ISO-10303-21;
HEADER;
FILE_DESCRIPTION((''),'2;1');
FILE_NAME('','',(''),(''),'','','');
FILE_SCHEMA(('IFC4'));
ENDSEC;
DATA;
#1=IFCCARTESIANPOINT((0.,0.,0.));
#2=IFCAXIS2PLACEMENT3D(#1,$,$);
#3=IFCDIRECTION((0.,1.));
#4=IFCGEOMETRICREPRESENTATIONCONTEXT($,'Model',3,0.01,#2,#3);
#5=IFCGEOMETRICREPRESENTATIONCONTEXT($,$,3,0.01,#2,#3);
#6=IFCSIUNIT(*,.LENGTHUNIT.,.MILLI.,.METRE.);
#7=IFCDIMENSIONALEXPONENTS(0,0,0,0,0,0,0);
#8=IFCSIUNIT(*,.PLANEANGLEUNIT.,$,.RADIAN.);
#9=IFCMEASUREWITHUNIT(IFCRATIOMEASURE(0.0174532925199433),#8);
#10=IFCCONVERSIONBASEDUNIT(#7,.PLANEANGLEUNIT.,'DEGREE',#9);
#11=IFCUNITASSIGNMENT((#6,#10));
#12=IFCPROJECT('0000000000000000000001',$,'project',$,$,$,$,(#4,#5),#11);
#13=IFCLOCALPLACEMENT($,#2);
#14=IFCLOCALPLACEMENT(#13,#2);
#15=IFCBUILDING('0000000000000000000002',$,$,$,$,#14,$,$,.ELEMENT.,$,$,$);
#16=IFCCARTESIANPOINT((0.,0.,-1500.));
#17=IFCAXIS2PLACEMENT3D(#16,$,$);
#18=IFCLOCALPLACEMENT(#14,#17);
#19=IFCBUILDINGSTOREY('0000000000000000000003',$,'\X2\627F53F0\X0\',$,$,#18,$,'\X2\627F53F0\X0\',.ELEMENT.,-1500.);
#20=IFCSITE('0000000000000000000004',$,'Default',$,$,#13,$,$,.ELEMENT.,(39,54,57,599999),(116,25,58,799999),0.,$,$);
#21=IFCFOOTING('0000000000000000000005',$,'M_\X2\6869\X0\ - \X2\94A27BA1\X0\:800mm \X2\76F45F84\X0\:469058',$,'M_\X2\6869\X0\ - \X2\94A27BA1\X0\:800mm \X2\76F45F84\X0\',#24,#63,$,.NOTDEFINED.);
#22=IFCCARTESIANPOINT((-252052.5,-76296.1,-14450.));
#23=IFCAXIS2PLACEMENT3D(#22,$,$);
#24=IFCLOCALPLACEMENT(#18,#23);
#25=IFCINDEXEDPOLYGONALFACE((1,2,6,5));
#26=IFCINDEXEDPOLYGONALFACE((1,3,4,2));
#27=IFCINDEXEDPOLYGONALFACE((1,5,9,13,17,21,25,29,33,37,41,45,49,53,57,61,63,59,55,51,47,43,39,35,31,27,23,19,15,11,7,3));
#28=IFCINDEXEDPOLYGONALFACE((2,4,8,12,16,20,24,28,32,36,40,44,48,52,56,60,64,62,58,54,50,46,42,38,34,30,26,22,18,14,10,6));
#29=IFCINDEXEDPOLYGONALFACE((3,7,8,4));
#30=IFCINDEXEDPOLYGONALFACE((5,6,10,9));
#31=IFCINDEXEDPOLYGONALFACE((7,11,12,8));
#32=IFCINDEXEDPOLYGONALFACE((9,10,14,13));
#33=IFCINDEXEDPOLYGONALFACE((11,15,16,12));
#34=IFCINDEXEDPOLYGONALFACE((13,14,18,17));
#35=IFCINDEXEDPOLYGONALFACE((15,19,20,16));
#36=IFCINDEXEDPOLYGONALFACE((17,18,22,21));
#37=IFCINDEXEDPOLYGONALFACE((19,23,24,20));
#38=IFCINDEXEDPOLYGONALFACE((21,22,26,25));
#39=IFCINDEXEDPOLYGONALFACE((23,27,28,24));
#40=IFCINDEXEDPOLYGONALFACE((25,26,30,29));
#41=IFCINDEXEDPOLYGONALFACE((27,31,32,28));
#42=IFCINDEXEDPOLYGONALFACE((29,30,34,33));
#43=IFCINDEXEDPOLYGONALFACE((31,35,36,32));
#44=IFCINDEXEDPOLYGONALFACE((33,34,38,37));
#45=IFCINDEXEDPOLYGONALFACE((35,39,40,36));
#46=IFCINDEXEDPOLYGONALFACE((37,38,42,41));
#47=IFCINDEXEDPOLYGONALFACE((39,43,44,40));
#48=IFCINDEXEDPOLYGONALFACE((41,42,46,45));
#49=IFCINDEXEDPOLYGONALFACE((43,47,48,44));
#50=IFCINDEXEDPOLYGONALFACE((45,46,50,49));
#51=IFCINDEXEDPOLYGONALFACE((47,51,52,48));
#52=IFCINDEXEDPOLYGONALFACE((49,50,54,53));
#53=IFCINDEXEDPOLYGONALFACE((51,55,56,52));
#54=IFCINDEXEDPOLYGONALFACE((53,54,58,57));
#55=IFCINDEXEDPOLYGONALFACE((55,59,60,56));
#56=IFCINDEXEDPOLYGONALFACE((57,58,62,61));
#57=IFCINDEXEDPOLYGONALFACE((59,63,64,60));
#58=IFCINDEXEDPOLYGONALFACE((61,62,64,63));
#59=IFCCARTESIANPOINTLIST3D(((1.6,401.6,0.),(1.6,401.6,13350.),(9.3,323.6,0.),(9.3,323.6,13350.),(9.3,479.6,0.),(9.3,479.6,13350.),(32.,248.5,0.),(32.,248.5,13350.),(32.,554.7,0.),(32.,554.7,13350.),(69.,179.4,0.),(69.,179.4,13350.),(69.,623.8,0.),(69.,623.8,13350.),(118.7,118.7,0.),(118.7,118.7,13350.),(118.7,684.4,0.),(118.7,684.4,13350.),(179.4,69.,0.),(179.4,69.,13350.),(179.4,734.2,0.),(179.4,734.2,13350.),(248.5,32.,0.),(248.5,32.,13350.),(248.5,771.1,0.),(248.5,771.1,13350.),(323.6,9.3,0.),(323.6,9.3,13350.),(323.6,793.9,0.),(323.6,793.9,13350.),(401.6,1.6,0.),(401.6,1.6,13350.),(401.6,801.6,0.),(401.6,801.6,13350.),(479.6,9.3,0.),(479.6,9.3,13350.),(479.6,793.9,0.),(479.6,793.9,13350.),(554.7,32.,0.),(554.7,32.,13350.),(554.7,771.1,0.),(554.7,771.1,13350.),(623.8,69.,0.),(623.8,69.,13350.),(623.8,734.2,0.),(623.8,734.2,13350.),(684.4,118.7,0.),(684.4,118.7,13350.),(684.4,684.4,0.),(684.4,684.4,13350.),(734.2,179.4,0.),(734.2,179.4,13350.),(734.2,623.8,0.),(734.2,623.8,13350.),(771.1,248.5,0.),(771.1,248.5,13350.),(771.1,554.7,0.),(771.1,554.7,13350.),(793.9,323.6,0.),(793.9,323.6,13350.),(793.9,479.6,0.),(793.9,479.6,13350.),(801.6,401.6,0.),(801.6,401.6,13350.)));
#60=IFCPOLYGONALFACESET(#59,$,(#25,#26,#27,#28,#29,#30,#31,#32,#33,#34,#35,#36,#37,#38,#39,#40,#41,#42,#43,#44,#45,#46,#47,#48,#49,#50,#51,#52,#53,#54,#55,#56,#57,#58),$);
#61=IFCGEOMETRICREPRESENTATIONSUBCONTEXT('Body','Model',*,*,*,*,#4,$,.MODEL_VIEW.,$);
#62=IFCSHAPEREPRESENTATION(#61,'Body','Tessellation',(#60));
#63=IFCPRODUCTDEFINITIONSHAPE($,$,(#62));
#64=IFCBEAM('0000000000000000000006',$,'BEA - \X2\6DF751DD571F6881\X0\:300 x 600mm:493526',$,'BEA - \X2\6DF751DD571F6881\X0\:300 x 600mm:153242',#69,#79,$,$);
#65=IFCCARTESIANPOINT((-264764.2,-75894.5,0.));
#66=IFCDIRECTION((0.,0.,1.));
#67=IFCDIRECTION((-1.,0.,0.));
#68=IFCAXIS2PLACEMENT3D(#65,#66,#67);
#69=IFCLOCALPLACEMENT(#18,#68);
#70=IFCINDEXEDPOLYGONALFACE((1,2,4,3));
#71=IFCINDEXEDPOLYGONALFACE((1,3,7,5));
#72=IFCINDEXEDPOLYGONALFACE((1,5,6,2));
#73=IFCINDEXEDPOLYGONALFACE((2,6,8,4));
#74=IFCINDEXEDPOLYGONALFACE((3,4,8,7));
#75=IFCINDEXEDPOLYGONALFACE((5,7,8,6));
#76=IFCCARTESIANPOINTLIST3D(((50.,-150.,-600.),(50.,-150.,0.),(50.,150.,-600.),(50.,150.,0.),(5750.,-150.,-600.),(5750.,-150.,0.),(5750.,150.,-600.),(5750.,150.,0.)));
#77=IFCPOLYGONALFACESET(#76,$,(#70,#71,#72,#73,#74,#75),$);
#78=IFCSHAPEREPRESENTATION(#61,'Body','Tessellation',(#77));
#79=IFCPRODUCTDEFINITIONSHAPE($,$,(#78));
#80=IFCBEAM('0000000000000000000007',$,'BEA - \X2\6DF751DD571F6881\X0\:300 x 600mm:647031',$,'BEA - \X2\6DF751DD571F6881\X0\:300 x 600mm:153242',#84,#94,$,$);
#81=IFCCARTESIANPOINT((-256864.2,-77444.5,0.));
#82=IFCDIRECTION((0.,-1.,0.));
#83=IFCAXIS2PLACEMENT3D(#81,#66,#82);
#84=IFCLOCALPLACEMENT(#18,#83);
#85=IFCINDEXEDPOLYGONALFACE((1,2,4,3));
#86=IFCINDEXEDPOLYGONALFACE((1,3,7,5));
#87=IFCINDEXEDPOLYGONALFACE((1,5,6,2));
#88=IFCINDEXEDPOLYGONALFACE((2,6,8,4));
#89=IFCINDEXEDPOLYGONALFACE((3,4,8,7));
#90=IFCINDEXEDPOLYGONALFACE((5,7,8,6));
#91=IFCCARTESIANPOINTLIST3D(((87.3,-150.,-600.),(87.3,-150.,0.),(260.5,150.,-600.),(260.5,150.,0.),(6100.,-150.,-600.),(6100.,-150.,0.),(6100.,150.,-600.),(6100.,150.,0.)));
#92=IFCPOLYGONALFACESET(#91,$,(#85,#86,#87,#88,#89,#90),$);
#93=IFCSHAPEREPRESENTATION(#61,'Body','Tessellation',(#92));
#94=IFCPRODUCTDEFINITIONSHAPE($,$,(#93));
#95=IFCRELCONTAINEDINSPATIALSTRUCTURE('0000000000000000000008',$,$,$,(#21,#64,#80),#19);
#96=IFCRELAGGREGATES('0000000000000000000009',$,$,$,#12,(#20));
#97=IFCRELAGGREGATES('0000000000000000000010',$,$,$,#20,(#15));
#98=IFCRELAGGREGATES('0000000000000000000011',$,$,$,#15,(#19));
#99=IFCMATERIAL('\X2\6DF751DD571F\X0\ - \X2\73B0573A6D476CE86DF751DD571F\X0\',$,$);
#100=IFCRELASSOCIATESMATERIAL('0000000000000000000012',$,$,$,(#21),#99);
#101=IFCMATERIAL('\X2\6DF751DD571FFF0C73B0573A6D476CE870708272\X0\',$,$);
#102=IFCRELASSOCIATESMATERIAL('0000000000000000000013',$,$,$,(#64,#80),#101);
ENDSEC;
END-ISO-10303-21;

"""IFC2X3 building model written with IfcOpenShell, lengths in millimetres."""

from ifc_helpers import new_model, entity, si_unit, converted_unit, direction, frame, frame_2d, origin, origin_2d_with_axis, place, context, subcontext, project, spatial, rectangle, circle, extrude, clip, halfspace, material, element, save


model = new_model("IFC2X3")

# Units and contexts
model_context = context("Model", 3, precision=0.01, world=origin(), true_north=direction((0.0, 1.0)))
context_of_model = context(None, 3, precision=0.01, world=origin(), true_north=direction((0.0, 1.0)))
body_context = subcontext(model_context, "Body", "Model", "MODEL_VIEW")
ifc_project = project(units=[si_unit("LENGTHUNIT", "METRE", prefix="MILLI"), converted_unit("PLANEANGLEUNIT", "DEGREE", entity("IfcRatioMeasure", 0.0174532925199433), si_unit("PLANEANGLEUNIT", "RADIAN"), dimensions=[0, 0, 0, 0, 0, 0, 0])], contexts=[model_context, context_of_model])

# Site, building, storey
site_placement = place(None, origin())
site = spatial("IfcSite", under=ifc_project, at=site_placement, Name="Default", CompositionType="ELEMENT", RefLatitude=(39, 54, 57, 599999), RefLongitude=(116, 25, 58, 799999), RefElevation=0.0)
building_placement = place(site_placement, origin())
building = spatial("IfcBuilding", under=site, at=building_placement, CompositionType="ELEMENT")
storey_placement = place(building_placement, frame((0.0, 0.0, -1500.0)))
storey = spatial("IfcBuildingStorey", under=building, at=storey_placement, Name="承台", LongName="承台", CompositionType="ELEMENT", Elevation=-1500.0)

# Footing
ifc_material_1 = material(Name="混凝土 - 现场浇注混凝土")
footing_1_placement = place(storey_placement, frame((-252052.5, -76296.1, -14450.0)))
element("IfcFooting", 1, at=footing_1_placement, inside=storey, material=ifc_material_1, Name="M_桩 - 钢管:800mm 直径:469058", ObjectType="M_桩 - 钢管:800mm 直径", PredefinedType="NOTDEFINED", context=body_context, shape_type="SweptSolid", body=[
    extrude(circle(Radius=400.0, at=origin_2d_with_axis()), frame((401.6, 401.6, 0.0), z_axis=(0.0, 0.0, 1.0), x_axis=(0.0, 1.0, 0.0)), (0.0, 0.0, 1.0), 13350.0),
])

# Shared definitions
ifc_material_2 = material(Name="混凝土，现场浇注灰色")

# Beams
beam_1_placement = place(storey_placement, frame((-264764.2, -75894.5, 0.0), z_axis=(0.0, 0.0, 1.0), x_axis=(-1.0, 0.0, 0.0)))
element("IfcBeam", 2, at=beam_1_placement, inside=storey, material=ifc_material_2, Name="BEA - 混凝土梁:300 x 600mm:493526", ObjectType="BEA - 混凝土梁:300 x 600mm:153242", context=body_context, shape_type="SweptSolid", body=[
    extrude(rectangle(XDim=600.0, YDim=300.0, at=frame_2d((0.0, 0.0), x_axis=(1.0, 0.0))), frame((50.0, 0.0, -300.0), z_axis=(1.0, 0.0, 0.0), x_axis=(0.0, 0.0, -1.0)), (0.0, 0.0, 1.0), 5700.0),
])
beam_2_placement = place(storey_placement, frame((-256864.2, -77444.5, 0.0), z_axis=(0.0, 0.0, 1.0), x_axis=(0.0, -1.0, 0.0)))
element("IfcBeam", 3, at=beam_2_placement, inside=storey, material=ifc_material_2, Name="BEA - 混凝土梁:300 x 600mm:647031", ObjectType="BEA - 混凝土梁:300 x 600mm:153242", context=body_context, shape_type="Clipping", body=[
    clip(extrude(rectangle(XDim=600.0, YDim=300.0, at=frame_2d((0.0, 0.0), x_axis=(1.0, 0.0))), frame((87.3, 0.0, -300.0), z_axis=(1.0, 0.0, 0.0), x_axis=(0.0, 0.0, -1.0)), (0.0, 0.0, 1.0), 6012.7), halfspace(frame((-1088.0, -2186.7, 0.0), z_axis=(-0.866125, 0.499827, 0.0), x_axis=(0.499827, 0.866125, 0.0)), False)),
])

save(model, "model.ifc")
